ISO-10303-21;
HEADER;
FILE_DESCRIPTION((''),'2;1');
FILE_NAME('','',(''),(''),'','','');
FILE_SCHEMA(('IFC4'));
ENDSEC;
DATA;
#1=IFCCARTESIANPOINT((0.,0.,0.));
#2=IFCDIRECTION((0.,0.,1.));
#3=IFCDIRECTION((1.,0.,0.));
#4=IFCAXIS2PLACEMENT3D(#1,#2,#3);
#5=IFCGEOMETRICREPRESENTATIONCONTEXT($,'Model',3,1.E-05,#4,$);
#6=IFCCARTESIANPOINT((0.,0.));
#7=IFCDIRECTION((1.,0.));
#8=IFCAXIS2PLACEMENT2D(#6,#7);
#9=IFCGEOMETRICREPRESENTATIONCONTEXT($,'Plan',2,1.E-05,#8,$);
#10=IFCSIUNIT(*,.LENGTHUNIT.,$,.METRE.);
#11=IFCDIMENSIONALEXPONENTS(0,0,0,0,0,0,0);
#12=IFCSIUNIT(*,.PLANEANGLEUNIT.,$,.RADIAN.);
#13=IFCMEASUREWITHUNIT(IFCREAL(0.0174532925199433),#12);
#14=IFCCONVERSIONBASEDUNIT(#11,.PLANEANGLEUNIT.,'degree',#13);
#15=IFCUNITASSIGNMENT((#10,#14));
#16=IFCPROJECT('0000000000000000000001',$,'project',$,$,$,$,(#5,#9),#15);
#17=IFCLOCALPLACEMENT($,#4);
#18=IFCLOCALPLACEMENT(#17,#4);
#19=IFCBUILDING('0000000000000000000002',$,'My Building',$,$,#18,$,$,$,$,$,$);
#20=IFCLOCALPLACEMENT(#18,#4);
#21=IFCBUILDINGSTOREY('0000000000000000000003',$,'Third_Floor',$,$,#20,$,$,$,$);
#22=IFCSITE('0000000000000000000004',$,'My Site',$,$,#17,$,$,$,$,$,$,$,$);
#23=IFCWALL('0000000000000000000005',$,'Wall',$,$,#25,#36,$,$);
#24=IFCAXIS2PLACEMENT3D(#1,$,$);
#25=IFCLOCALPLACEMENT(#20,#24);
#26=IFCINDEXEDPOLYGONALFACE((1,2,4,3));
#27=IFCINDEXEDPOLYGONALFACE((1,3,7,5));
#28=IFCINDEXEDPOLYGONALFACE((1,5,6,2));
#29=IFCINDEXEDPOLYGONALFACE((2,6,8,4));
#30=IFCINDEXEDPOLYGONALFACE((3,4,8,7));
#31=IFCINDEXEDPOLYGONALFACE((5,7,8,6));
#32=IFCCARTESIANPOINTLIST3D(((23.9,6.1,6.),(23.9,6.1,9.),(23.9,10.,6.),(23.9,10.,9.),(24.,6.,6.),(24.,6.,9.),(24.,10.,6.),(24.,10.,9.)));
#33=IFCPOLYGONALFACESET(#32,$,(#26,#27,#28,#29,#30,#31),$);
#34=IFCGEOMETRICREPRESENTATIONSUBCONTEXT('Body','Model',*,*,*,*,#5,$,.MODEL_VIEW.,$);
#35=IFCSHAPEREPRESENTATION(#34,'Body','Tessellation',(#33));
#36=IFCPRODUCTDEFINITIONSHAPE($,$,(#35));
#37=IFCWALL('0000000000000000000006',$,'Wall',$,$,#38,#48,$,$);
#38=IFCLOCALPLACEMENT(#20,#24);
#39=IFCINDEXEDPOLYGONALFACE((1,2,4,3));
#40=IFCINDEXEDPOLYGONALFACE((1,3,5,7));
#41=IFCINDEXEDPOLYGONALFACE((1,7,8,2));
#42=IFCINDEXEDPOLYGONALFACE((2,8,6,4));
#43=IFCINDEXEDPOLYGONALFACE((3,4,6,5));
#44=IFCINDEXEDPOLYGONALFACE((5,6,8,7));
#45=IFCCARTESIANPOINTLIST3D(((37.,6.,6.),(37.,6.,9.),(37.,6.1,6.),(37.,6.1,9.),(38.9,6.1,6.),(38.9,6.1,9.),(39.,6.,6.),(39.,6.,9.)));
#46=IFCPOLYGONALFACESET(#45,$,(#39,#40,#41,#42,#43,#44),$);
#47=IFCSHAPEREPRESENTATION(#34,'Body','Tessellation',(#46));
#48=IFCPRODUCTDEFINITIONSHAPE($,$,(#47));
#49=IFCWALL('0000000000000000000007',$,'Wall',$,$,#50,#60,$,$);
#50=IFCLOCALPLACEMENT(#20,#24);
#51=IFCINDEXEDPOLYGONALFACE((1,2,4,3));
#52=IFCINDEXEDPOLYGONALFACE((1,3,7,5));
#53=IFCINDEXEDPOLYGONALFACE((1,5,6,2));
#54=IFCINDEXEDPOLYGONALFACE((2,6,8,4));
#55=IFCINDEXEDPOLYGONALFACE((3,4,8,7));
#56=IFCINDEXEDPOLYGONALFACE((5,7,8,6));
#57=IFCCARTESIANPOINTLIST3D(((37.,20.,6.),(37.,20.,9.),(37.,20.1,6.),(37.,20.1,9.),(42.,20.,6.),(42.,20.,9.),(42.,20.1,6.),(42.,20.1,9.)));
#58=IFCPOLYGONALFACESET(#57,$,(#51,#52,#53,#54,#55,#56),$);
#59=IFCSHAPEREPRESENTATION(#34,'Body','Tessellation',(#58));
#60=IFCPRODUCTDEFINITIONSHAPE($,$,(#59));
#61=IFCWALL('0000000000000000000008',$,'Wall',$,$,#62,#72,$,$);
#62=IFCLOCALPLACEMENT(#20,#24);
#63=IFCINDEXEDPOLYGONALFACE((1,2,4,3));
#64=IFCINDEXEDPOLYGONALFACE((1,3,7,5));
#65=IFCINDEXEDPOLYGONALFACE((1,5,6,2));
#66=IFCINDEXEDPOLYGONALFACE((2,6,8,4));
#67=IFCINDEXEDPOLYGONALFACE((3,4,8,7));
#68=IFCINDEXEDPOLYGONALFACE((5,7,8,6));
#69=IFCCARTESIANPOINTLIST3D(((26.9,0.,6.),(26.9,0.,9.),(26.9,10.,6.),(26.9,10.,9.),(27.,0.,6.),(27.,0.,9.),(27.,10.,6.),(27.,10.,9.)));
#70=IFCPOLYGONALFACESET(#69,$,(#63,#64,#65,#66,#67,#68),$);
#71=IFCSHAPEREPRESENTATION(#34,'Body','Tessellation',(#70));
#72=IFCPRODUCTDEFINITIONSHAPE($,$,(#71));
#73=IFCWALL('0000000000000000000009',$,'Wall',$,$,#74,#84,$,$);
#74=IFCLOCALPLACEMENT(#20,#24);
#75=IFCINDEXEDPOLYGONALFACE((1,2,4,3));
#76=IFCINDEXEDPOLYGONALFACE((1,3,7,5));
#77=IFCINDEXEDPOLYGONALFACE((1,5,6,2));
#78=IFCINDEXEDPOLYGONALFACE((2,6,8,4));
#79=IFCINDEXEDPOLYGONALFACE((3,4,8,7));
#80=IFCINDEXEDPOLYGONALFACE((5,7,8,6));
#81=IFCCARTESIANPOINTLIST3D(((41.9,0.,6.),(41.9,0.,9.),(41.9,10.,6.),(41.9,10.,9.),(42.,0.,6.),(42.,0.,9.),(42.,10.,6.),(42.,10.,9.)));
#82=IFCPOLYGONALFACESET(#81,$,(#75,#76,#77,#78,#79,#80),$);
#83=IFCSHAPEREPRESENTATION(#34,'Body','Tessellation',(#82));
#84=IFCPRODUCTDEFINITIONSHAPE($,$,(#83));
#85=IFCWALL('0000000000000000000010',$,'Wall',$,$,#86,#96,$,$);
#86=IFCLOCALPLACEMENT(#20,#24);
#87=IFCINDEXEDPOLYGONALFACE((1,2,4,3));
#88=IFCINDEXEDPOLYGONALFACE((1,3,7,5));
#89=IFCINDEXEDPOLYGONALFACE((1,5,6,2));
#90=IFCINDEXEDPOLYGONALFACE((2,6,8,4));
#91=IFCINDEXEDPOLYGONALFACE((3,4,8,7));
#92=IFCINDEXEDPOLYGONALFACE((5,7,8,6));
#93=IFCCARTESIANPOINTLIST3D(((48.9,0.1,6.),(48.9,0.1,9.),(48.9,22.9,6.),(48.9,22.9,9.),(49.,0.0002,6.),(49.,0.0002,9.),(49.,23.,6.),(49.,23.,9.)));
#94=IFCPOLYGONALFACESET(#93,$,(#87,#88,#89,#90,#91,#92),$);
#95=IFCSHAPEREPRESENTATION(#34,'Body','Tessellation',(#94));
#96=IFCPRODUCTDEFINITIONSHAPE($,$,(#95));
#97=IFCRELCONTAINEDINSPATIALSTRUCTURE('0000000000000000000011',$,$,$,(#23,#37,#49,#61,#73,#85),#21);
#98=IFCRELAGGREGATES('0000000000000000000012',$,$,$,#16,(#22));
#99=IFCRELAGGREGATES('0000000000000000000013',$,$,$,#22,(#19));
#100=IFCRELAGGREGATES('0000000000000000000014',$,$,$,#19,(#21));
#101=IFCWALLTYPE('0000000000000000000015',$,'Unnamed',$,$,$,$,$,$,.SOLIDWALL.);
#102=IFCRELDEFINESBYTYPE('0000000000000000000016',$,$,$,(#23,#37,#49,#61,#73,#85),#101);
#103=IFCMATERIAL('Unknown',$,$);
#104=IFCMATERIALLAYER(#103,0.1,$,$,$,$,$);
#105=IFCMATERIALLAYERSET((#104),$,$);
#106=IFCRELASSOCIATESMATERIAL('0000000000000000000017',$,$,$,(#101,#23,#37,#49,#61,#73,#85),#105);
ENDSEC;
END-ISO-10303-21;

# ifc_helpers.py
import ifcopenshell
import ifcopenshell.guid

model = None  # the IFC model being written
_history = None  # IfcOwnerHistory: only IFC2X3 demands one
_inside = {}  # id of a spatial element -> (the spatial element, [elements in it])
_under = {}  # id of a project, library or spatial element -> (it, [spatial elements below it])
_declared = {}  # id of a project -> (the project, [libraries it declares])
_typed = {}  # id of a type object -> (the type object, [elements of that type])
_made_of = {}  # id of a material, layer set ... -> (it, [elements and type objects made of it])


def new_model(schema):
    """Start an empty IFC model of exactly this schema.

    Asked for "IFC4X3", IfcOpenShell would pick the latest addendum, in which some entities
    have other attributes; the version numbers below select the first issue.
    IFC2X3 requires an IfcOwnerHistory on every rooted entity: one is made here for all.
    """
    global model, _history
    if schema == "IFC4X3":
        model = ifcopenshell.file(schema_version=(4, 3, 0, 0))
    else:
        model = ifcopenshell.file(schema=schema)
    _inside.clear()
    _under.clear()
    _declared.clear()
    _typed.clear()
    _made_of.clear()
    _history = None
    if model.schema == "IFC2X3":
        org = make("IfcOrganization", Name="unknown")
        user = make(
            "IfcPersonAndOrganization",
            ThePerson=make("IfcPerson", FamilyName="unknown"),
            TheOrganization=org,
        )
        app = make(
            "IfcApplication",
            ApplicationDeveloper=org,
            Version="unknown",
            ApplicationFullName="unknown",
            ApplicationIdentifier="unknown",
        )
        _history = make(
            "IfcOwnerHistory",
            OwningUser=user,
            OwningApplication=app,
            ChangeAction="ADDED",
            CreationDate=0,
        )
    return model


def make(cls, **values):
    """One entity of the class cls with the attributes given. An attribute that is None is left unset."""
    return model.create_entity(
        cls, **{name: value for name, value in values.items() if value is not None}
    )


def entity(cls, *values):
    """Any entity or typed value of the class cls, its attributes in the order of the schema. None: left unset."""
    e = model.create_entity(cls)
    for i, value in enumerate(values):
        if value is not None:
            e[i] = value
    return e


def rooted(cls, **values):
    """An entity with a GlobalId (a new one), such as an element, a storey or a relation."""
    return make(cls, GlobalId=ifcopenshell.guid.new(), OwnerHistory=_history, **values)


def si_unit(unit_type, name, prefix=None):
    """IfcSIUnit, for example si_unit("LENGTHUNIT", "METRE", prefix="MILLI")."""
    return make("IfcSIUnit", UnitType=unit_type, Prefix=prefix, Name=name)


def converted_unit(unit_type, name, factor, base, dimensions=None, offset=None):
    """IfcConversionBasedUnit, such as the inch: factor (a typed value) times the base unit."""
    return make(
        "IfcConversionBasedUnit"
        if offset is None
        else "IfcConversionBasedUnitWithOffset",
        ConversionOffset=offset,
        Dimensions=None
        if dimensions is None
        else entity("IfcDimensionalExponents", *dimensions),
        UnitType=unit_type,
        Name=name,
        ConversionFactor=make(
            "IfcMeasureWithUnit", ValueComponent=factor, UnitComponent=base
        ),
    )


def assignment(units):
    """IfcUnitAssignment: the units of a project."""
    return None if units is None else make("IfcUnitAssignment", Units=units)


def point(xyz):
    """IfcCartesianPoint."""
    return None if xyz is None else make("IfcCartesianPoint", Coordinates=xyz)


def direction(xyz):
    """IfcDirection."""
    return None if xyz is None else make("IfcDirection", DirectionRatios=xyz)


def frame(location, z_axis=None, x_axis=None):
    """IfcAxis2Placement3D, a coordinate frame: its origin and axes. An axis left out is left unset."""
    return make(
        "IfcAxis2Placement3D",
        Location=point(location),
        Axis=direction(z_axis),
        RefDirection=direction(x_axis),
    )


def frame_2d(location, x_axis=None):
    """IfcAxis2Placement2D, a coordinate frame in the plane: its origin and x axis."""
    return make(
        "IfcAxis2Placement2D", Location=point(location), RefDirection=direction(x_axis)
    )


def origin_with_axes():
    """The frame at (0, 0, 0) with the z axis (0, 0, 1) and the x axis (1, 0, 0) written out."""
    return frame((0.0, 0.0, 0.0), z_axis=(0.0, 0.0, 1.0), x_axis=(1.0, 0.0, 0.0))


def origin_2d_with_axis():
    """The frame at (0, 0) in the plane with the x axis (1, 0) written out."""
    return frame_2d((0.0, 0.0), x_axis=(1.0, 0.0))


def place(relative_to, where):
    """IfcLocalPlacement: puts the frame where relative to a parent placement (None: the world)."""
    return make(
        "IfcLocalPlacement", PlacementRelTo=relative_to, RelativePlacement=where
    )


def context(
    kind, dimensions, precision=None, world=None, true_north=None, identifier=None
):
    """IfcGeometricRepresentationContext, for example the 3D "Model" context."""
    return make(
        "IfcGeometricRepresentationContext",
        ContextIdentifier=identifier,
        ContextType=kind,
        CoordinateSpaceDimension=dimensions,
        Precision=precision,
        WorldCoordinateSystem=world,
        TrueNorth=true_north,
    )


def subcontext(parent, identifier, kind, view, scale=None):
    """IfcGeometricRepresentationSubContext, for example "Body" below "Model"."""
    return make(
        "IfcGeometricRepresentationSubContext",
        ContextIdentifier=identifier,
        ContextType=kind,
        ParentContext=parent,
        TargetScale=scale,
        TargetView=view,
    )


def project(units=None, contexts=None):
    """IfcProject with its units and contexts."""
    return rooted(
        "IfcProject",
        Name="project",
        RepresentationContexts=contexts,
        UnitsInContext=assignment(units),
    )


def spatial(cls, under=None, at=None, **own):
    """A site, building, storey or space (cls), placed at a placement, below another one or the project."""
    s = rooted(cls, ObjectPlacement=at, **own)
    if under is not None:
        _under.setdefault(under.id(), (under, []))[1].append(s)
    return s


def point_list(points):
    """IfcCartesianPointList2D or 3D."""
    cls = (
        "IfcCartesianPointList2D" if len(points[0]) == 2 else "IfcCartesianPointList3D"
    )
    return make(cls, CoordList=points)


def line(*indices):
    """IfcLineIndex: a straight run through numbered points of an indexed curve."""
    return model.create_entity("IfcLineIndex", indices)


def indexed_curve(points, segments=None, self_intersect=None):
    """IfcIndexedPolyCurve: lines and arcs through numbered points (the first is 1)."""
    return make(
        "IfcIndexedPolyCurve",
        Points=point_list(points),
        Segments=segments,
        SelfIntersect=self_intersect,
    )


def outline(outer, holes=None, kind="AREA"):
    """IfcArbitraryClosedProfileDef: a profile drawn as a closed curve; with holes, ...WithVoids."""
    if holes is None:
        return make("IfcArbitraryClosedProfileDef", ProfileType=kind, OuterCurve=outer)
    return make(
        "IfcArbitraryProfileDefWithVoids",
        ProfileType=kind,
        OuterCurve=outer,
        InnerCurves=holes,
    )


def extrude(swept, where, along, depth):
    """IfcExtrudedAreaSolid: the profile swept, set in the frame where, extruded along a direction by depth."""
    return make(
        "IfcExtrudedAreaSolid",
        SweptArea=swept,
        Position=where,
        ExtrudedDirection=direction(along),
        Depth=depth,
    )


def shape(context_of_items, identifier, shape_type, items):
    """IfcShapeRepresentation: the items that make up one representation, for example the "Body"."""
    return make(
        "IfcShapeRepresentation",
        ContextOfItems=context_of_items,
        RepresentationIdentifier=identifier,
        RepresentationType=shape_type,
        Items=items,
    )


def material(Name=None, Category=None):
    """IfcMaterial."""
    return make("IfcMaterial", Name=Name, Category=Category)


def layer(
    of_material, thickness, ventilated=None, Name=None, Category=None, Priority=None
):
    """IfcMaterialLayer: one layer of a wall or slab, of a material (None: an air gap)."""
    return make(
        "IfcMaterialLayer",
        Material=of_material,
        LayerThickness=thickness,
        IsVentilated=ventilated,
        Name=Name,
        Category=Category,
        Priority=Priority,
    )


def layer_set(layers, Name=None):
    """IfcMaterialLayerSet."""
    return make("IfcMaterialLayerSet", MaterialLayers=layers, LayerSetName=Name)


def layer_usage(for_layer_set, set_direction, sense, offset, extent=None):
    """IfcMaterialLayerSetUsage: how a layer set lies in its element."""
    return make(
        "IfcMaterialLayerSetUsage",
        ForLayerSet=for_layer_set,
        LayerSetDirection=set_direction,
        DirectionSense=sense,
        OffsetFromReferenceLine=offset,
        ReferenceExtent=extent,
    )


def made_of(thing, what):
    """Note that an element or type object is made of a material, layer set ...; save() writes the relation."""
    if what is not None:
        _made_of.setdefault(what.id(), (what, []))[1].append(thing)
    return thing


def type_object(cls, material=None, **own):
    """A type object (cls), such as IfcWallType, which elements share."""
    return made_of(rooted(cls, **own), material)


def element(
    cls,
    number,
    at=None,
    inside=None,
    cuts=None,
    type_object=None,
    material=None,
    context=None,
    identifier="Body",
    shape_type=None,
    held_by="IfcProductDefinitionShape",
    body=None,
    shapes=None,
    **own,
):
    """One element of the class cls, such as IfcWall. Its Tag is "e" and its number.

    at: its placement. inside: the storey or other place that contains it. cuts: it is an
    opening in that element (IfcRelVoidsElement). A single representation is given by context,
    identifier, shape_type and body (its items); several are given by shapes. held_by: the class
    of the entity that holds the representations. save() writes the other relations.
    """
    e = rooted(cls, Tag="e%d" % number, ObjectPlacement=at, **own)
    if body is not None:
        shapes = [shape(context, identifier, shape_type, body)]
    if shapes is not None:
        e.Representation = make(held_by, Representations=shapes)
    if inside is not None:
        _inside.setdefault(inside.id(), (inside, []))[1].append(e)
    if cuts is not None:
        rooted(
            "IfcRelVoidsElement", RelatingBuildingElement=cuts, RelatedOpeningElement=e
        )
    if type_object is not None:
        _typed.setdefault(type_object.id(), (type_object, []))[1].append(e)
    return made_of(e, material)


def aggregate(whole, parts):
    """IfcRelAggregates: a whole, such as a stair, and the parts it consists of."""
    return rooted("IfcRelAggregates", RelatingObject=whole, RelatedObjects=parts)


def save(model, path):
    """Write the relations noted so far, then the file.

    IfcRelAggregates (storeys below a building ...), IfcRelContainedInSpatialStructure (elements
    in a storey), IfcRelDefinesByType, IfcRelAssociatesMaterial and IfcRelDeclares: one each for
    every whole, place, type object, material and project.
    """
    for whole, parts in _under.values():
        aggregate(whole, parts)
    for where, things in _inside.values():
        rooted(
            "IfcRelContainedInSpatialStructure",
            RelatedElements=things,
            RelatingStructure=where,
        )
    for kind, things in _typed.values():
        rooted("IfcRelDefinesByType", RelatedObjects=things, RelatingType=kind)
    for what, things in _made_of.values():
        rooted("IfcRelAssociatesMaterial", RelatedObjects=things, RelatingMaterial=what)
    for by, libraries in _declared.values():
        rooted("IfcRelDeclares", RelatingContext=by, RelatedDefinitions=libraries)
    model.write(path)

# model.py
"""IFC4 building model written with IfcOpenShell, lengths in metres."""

from ifc_helpers import new_model, entity, si_unit, converted_unit, frame, origin_with_axes, origin_2d_with_axis, place, context, subcontext, project, spatial, line, indexed_curve, outline, extrude, material, layer, layer_set, layer_usage, type_object, element, save


model = new_model("IFC4")

# Units and contexts
model_context = context("Model", 3, precision=1e-05, world=origin_with_axes())
plan_context = context("Plan", 2, precision=1e-05, world=origin_2d_with_axis())
body_context = subcontext(model_context, "Body", "Model", "MODEL_VIEW")
ifc_project = project(units=[si_unit("LENGTHUNIT", "METRE"), converted_unit("PLANEANGLEUNIT", "degree", entity("IfcReal", 0.0174532925199433), si_unit("PLANEANGLEUNIT", "RADIAN"), dimensions=[0, 0, 0, 0, 0, 0, 0])], contexts=[model_context, plan_context])

# Site, building, storey
site_placement = place(None, origin_with_axes())
site = spatial("IfcSite", under=ifc_project, at=site_placement, Name="My Site")
building_placement = place(site_placement, origin_with_axes())
building = spatial("IfcBuilding", under=site, at=building_placement, Name="My Building")
storey_placement = place(building_placement, origin_with_axes())
storey = spatial("IfcBuildingStorey", under=building, at=storey_placement, Name="Third_Floor")

# Walls
ifc_material = material(Name="Unknown")
ifc_layer = layer(ifc_material, 0.1)
ifc_layer_set = layer_set([ifc_layer])
wall_type = type_object("IfcWallType", Name="Unnamed", PredefinedType="SOLIDWALL", material=ifc_layer_set)
ifc_layer_usage_1 = layer_usage(ifc_layer_set, "AXIS2", "POSITIVE", 0.0)
wall_1_placement = place(storey_placement, frame((24.0, 6.0, 6.0), z_axis=(0.0, 0.0, 1.0), x_axis=(0.0, 1.0, 0.0)))
element("IfcWall", 1, at=wall_1_placement, inside=storey, type_object=wall_type, material=ifc_layer_usage_1, Name="Wall", context=body_context, shape_type="SweptSolid", body=[
    extrude(outline(indexed_curve([(0.0, 0.0), (0.1, 0.1), (4.0, 0.1), (4.0, 0.0)], segments=[line(1, 2, 3, 4, 1)])), origin_with_axes(), (0.0, 0.0, 1.0), 3.0),
])
ifc_layer_usage_2 = layer_usage(ifc_layer_set, "AXIS2", "POSITIVE", 0.0)
wall_2_placement = place(storey_placement, frame((37.0, 6.0, 6.0), z_axis=(0.0, 0.0, 1.0), x_axis=(1.0, 0.0, 0.0)))
element("IfcWall", 2, at=wall_2_placement, inside=storey, type_object=wall_type, material=ifc_layer_usage_2, Name="Wall", context=body_context, shape_type="SweptSolid", body=[
    extrude(outline(indexed_curve([(0.0, 0.0), (0.0, 0.1), (1.9, 0.1), (2.0, 0.0)], segments=[line(1, 2, 3, 4, 1)])), origin_with_axes(), (0.0, 0.0, 1.0), 3.0),
])
ifc_layer_usage_3 = layer_usage(ifc_layer_set, "AXIS2", "POSITIVE", 0.0)
wall_3_placement = place(storey_placement, frame((37.0, 20.0, 6.0), z_axis=(0.0, 0.0, 1.0), x_axis=(1.0, 0.0, 0.0)))
element("IfcWall", 3, at=wall_3_placement, inside=storey, type_object=wall_type, material=ifc_layer_usage_3, Name="Wall", context=body_context, shape_type="SweptSolid", body=[
    extrude(outline(indexed_curve([(0.0, 0.0), (0.0, 0.1), (5.0, 0.1), (5.0, 0.0)], segments=[line(1, 2, 3, 4, 1)])), origin_with_axes(), (0.0, 0.0, 1.0), 3.0),
])
ifc_layer_usage_4 = layer_usage(ifc_layer_set, "AXIS2", "POSITIVE", 0.0)
wall_4_placement = place(storey_placement, frame((26.9, 10.0, 6.0), z_axis=(0.0, 0.0, 1.0), x_axis=(0.0, -1.0, 0.0)))
element("IfcWall", 4, at=wall_4_placement, inside=storey, type_object=wall_type, material=ifc_layer_usage_4, Name="Wall", context=body_context, shape_type="SweptSolid", body=[
    extrude(outline(indexed_curve([(0.0, 0.0), (0.0, 0.1), (10.0, 0.1), (10.0, 0.0)], segments=[line(1, 2, 3, 4, 1)])), origin_with_axes(), (0.0, 0.0, 1.0), 3.0),
])
ifc_layer_usage_5 = layer_usage(ifc_layer_set, "AXIS2", "POSITIVE", 0.0)
wall_5_placement = place(storey_placement, frame((41.9, 10.0, 6.0), z_axis=(0.0, 0.0, 1.0), x_axis=(0.0, -1.0, 0.0)))
element("IfcWall", 5, at=wall_5_placement, inside=storey, type_object=wall_type, material=ifc_layer_usage_5, Name="Wall", context=body_context, shape_type="SweptSolid", body=[
    extrude(outline(indexed_curve([(0.0, 0.0), (0.0, 0.1), (10.0, 0.1), (10.0, 0.0)], segments=[line(1, 2, 3, 4, 1)])), origin_with_axes(), (0.0, 0.0, 1.0), 3.0),
])
ifc_layer_usage_6 = layer_usage(ifc_layer_set, "AXIS2", "POSITIVE", 0.0)
wall_6_placement = place(storey_placement, frame((48.9, 22.9, 6.0), z_axis=(0.0, 0.0, 1.0), x_axis=(0.0, -1.0, 0.0)))
element("IfcWall", 6, at=wall_6_placement, inside=storey, type_object=wall_type, material=ifc_layer_usage_6, Name="Wall", context=body_context, shape_type="SweptSolid", body=[
    extrude(outline(indexed_curve([(0.0, 0.0), (-0.1, 0.1), (22.8998, 0.1), (22.8, 0.0)], segments=[line(1, 2, 3, 4, 1)])), origin_with_axes(), (0.0, 0.0, 1.0), 3.0),
])

save(model, "model.ifc")
